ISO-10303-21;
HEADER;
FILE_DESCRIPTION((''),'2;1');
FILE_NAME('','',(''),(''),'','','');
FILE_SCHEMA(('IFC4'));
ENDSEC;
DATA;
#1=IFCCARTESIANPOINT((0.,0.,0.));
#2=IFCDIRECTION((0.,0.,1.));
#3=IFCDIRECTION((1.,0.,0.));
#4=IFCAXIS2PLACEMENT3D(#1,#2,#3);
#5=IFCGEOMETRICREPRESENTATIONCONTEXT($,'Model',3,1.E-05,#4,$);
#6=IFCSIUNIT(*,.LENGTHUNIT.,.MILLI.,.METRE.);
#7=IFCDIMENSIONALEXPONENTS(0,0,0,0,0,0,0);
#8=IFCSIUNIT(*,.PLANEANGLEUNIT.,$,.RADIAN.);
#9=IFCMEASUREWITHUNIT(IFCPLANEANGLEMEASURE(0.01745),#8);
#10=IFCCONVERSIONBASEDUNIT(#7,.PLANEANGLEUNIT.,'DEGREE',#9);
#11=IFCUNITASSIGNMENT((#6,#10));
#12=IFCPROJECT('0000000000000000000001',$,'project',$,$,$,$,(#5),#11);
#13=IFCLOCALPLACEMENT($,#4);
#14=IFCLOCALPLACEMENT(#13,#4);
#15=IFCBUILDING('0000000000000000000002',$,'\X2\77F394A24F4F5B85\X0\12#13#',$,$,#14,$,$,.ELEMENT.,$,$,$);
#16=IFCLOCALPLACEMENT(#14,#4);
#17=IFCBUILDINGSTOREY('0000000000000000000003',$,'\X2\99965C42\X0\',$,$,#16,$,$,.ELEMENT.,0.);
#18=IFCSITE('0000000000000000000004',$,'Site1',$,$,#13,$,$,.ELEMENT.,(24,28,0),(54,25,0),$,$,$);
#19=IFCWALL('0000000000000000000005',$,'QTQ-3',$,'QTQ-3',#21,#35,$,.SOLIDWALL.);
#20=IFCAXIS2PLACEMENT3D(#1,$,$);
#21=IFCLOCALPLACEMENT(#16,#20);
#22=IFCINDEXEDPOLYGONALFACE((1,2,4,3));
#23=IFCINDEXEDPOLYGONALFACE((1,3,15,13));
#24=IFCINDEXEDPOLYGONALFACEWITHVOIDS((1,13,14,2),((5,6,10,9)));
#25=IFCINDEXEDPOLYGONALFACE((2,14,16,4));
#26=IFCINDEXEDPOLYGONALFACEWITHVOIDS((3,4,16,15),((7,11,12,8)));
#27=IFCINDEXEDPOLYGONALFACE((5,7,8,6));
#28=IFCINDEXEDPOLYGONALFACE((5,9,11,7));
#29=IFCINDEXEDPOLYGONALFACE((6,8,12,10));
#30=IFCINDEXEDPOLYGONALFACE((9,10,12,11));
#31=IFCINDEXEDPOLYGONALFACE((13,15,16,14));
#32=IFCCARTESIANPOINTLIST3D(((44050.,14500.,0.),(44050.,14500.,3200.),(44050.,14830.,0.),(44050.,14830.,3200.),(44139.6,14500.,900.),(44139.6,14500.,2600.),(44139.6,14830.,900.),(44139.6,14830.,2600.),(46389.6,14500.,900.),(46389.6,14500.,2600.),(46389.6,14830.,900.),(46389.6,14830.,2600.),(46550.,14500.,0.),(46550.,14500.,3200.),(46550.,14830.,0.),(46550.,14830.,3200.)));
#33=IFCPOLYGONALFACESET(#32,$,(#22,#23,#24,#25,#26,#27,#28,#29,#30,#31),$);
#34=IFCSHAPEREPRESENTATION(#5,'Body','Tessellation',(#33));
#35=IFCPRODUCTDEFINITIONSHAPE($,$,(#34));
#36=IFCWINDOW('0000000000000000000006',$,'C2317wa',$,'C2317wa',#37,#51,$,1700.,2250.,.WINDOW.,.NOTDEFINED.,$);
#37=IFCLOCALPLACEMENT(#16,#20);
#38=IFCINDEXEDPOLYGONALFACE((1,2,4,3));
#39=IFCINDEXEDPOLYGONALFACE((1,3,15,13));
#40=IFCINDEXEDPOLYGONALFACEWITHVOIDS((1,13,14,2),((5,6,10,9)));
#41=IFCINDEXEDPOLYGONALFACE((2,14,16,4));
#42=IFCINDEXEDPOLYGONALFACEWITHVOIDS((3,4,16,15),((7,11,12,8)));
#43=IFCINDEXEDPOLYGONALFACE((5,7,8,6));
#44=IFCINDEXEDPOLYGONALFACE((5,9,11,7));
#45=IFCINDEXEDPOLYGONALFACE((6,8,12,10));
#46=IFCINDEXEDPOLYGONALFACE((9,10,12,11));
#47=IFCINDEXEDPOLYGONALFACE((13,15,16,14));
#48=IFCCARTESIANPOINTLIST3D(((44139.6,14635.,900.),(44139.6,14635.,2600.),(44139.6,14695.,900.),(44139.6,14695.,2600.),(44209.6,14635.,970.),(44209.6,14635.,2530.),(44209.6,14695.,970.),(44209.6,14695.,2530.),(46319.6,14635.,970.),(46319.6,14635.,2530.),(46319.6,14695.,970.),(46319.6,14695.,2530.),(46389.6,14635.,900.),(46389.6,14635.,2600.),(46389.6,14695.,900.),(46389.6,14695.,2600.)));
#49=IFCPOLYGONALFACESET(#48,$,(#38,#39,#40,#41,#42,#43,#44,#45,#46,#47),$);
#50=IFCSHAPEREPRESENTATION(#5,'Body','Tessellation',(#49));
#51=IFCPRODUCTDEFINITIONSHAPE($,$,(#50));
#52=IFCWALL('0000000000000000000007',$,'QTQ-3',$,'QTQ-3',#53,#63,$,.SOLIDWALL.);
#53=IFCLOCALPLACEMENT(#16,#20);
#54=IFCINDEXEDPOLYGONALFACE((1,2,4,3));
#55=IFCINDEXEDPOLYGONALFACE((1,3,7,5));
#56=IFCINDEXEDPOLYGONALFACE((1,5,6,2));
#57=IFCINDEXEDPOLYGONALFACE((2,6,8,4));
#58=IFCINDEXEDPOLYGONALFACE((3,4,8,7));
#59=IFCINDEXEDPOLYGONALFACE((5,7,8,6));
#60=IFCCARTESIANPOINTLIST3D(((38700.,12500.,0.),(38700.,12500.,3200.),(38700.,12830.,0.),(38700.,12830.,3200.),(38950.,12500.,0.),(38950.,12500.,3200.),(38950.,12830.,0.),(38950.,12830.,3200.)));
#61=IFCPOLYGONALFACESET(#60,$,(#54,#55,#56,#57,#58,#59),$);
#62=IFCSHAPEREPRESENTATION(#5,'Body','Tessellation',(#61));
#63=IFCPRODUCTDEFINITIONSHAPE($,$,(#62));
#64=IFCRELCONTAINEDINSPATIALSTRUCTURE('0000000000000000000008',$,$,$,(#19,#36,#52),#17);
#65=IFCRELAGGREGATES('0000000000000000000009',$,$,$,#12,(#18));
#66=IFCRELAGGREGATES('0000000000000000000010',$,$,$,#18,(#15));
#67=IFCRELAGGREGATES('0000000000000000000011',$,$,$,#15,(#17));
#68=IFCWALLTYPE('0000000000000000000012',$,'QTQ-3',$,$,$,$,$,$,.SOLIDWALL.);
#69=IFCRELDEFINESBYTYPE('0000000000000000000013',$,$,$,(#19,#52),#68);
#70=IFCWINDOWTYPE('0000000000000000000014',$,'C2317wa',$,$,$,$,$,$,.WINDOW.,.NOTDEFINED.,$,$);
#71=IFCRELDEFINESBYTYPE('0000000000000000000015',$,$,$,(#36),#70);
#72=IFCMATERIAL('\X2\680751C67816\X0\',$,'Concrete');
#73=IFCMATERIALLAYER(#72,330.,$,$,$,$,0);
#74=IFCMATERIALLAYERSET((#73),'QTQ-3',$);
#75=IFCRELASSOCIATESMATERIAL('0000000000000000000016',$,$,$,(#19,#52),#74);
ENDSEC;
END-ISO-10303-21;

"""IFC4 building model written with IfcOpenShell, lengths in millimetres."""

from ifc_helpers import new_model, entity, si_unit, converted_unit, frame, origin_with_axes, place, context, project, spatial, polyline, outline, extrude, material, layer, layer_set, type_object, element, fill, save


model = new_model("IFC4")

# Units and contexts
model_context = context("Model", 3, precision=1e-05, world=origin_with_axes())
ifc_project = project(units=[si_unit("LENGTHUNIT", "METRE", prefix="MILLI"), converted_unit("PLANEANGLEUNIT", "DEGREE", entity("IfcPlaneAngleMeasure", 0.01745), si_unit("PLANEANGLEUNIT", "RADIAN"), dimensions=[0, 0, 0, 0, 0, 0, 0])], contexts=[model_context])

# Site, building, storey
site_placement = place(None, origin_with_axes())
site = spatial("IfcSite", under=ifc_project, at=site_placement, Name="Site1", CompositionType="ELEMENT", RefLatitude=(24, 28, 0), RefLongitude=(54, 25, 0))
building_placement = place(site_placement, origin_with_axes())
building = spatial("IfcBuilding", under=site, at=building_placement, Name="石钢住宅12#13#", CompositionType="ELEMENT")
storey_placement = place(building_placement, origin_with_axes())
storey = spatial("IfcBuildingStorey", under=building, at=storey_placement, Name="首层", CompositionType="ELEMENT", Elevation=0.0)

# Shared definitions
ifc_material_1 = material(Name="标准砖", Category="Concrete")
ifc_layer_1 = layer(ifc_material_1, 330.0, Priority=0)
ifc_layer_set_1 = layer_set([ifc_layer_1], Name="QTQ-3")
wall_type_1 = type_object("IfcWallType", Name="QTQ-3", PredefinedType="SOLIDWALL")

# Wall, opening, window
wall_1_placement = place(storey_placement, origin_with_axes())
wall_1 = element("IfcWall", 1, at=wall_1_placement, inside=storey, type_object=wall_type_1, material=ifc_layer_set_1, Name="QTQ-3", ObjectType="QTQ-3", PredefinedType="SOLIDWALL", context=model_context, shape_type="SweptSolid", body=[
    extrude(outline(polyline([(0.0, 0.0), (3200.0, 0.0), (3200.0, 2500.0), (0.0, 2500.0), (0.0, 0.0)])), frame((44050.0, 14830.0, 3200.0), z_axis=(0.0, -1.0, 0.0), x_axis=(0.0, 0.0, -1.0)), (0.0, 0.0, 1.0), 330.0),
])
opening_1_placement = place(storey_placement, origin_with_axes())
opening_1 = element("IfcOpeningElement", 2, at=opening_1_placement, cuts=wall_1, PredefinedType="OPENING", context=model_context, shape_type="SweptSolid", body=[
    extrude(outline(polyline([(0.0, 0.0), (2250.0, 0.0), (2250.0, 1700.0), (0.0, 1700.0), (0.0, 0.0)])), frame((44139.6, 15830.0, 900.0), z_axis=(0.0, -1.0, 0.0), x_axis=(1.0, 0.0, 0.0)), (0.0, 0.0, 1.0), 2330.0),
])
window_type_1 = type_object("IfcWindowType", Name="C2317wa", PartitioningType="NOTDEFINED", PredefinedType="WINDOW")
window_1_placement = place(storey_placement, origin_with_axes())
window_1 = element("IfcWindow", 3, at=window_1_placement, inside=storey, type_object=window_type_1, Name="C2317wa", ObjectType="C2317wa", OverallHeight=1700.0, OverallWidth=2250.0, PartitioningType="NOTDEFINED", PredefinedType="WINDOW", context=model_context, shape_type="SweptSolid", body=[
    extrude(outline(polyline([(-1125.0, -850.0), (1125.0, -850.0), (1125.0, 850.0), (-1125.0, 850.0), (-1125.0, -850.0)]), holes=[polyline([(-1055.0, -780.0), (-1055.0, 780.0), (1055.0, 780.0), (1055.0, -780.0), (-1055.0, -780.0)])]), frame((45264.6, 14695.0, 1750.0), z_axis=(0.0, -1.0, 0.0), x_axis=(1.0, 0.0, 0.0)), (0.0, 0.0, 1.0), 60.0),
])
fill(opening_1, window_1)

# Wall
wall_2_placement = place(storey_placement, origin_with_axes())
element("IfcWall", 4, at=wall_2_placement, inside=storey, type_object=wall_type_1, material=ifc_layer_set_1, Name="QTQ-3", ObjectType="QTQ-3", PredefinedType="SOLIDWALL", context=model_context, shape_type="SweptSolid", body=[
    extrude(outline(polyline([(0.0, 0.0), (3200.0, 0.0), (3200.0, 250.0), (0.0, 250.0), (0.0, 0.0)])), frame((38950.0, 12500.0, 3200.0), z_axis=(0.0, 1.0, 0.0), x_axis=(0.0, 0.0, -1.0)), (0.0, 0.0, 1.0), 330.0),
])

save(model, "model.ifc")
